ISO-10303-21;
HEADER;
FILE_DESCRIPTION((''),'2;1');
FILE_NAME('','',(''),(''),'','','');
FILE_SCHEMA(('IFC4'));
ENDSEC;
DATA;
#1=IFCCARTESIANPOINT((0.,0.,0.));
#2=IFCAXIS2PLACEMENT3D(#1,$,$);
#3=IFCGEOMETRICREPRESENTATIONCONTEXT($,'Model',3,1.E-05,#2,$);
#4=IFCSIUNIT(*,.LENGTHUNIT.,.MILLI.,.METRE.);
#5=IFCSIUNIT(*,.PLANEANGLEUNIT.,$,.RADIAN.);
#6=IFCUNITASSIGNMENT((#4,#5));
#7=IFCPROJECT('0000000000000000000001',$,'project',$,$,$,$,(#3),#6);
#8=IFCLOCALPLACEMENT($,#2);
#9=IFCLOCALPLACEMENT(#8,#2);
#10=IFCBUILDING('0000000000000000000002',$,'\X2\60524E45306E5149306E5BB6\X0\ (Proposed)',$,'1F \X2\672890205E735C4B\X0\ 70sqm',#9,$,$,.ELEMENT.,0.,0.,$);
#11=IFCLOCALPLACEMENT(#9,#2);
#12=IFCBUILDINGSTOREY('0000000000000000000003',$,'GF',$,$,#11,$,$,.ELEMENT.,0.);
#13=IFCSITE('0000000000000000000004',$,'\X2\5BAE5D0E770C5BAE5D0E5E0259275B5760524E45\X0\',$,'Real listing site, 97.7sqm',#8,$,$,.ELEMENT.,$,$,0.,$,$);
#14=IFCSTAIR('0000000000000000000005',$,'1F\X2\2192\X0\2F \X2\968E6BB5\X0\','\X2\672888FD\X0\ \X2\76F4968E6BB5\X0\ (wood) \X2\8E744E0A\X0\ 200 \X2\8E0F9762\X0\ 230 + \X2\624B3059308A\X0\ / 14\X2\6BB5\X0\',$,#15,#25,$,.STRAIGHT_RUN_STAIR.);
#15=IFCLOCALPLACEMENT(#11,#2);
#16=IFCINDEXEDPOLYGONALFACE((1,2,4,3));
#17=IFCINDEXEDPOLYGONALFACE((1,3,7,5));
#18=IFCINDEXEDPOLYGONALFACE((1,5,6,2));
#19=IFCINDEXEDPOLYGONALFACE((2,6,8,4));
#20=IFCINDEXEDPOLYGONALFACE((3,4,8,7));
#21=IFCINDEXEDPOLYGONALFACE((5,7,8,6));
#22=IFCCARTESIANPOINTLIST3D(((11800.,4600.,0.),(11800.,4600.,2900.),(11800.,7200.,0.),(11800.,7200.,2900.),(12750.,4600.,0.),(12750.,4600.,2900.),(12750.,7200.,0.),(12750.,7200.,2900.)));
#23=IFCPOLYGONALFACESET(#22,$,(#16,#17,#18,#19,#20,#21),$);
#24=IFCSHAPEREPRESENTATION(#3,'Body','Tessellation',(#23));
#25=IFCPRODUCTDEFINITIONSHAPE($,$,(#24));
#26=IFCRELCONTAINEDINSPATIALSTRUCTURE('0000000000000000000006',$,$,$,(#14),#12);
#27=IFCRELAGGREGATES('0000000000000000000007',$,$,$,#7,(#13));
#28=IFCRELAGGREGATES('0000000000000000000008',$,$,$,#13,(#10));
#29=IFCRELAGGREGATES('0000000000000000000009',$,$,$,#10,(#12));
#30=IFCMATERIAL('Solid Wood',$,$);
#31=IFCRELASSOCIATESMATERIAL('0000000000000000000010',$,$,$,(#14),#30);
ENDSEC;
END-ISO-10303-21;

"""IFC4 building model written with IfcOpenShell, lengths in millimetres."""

from ifc_helpers import new_model, si_unit, frame, frame_2d, origin, place, context, project, spatial, rectangle, extrude, material, element, save


model = new_model("IFC4")

# Units and contexts
model_context = context("Model", 3, precision=1e-05, world=origin())
ifc_project = project(units=[si_unit("LENGTHUNIT", "METRE", prefix="MILLI"), si_unit("PLANEANGLEUNIT", "RADIAN")], contexts=[model_context])

# Site, building, storey
site_placement = place(None, origin())
site = spatial("IfcSite", under=ifc_project, at=site_placement, Name="宮崎県宮崎市大字恒久", ObjectType="Real listing site, 97.7sqm", CompositionType="ELEMENT", RefElevation=0.0)
building_placement = place(site_placement, origin())
building = spatial("IfcBuilding", under=site, at=building_placement, Name="恒久の光の家 (Proposed)", ObjectType="1F 木造平屋 70sqm", CompositionType="ELEMENT", ElevationOfRefHeight=0.0, ElevationOfTerrain=0.0)
storey_placement = place(building_placement, origin())
storey = spatial("IfcBuildingStorey", under=building, at=storey_placement, Name="GF", CompositionType="ELEMENT", Elevation=0.0)

# Shared definitions
ifc_material_1 = material(Name="Solid Wood")

# Stair
stair_placement = place(storey_placement, frame((5900.0, 2300.0, 0.0)))
element("IfcStair", 1, at=stair_placement, inside=storey, material=ifc_material_1, Name="1F→2F 階段", Description="木製 直階段 (wood) 蹴上 200 踏面 230 + 手すり / 14段", PredefinedType="STRAIGHT_RUN_STAIR", context=model_context, shape_type="SweptSolid", body=[
    extrude(rectangle(XDim=950.0, YDim=2600.0, at=frame_2d((475.0, 1300.0))), frame((5900.0, 2300.0, 0.0)), (0.0, 0.0, 1.0), 2900.0),
])

save(model, "model.ifc")
